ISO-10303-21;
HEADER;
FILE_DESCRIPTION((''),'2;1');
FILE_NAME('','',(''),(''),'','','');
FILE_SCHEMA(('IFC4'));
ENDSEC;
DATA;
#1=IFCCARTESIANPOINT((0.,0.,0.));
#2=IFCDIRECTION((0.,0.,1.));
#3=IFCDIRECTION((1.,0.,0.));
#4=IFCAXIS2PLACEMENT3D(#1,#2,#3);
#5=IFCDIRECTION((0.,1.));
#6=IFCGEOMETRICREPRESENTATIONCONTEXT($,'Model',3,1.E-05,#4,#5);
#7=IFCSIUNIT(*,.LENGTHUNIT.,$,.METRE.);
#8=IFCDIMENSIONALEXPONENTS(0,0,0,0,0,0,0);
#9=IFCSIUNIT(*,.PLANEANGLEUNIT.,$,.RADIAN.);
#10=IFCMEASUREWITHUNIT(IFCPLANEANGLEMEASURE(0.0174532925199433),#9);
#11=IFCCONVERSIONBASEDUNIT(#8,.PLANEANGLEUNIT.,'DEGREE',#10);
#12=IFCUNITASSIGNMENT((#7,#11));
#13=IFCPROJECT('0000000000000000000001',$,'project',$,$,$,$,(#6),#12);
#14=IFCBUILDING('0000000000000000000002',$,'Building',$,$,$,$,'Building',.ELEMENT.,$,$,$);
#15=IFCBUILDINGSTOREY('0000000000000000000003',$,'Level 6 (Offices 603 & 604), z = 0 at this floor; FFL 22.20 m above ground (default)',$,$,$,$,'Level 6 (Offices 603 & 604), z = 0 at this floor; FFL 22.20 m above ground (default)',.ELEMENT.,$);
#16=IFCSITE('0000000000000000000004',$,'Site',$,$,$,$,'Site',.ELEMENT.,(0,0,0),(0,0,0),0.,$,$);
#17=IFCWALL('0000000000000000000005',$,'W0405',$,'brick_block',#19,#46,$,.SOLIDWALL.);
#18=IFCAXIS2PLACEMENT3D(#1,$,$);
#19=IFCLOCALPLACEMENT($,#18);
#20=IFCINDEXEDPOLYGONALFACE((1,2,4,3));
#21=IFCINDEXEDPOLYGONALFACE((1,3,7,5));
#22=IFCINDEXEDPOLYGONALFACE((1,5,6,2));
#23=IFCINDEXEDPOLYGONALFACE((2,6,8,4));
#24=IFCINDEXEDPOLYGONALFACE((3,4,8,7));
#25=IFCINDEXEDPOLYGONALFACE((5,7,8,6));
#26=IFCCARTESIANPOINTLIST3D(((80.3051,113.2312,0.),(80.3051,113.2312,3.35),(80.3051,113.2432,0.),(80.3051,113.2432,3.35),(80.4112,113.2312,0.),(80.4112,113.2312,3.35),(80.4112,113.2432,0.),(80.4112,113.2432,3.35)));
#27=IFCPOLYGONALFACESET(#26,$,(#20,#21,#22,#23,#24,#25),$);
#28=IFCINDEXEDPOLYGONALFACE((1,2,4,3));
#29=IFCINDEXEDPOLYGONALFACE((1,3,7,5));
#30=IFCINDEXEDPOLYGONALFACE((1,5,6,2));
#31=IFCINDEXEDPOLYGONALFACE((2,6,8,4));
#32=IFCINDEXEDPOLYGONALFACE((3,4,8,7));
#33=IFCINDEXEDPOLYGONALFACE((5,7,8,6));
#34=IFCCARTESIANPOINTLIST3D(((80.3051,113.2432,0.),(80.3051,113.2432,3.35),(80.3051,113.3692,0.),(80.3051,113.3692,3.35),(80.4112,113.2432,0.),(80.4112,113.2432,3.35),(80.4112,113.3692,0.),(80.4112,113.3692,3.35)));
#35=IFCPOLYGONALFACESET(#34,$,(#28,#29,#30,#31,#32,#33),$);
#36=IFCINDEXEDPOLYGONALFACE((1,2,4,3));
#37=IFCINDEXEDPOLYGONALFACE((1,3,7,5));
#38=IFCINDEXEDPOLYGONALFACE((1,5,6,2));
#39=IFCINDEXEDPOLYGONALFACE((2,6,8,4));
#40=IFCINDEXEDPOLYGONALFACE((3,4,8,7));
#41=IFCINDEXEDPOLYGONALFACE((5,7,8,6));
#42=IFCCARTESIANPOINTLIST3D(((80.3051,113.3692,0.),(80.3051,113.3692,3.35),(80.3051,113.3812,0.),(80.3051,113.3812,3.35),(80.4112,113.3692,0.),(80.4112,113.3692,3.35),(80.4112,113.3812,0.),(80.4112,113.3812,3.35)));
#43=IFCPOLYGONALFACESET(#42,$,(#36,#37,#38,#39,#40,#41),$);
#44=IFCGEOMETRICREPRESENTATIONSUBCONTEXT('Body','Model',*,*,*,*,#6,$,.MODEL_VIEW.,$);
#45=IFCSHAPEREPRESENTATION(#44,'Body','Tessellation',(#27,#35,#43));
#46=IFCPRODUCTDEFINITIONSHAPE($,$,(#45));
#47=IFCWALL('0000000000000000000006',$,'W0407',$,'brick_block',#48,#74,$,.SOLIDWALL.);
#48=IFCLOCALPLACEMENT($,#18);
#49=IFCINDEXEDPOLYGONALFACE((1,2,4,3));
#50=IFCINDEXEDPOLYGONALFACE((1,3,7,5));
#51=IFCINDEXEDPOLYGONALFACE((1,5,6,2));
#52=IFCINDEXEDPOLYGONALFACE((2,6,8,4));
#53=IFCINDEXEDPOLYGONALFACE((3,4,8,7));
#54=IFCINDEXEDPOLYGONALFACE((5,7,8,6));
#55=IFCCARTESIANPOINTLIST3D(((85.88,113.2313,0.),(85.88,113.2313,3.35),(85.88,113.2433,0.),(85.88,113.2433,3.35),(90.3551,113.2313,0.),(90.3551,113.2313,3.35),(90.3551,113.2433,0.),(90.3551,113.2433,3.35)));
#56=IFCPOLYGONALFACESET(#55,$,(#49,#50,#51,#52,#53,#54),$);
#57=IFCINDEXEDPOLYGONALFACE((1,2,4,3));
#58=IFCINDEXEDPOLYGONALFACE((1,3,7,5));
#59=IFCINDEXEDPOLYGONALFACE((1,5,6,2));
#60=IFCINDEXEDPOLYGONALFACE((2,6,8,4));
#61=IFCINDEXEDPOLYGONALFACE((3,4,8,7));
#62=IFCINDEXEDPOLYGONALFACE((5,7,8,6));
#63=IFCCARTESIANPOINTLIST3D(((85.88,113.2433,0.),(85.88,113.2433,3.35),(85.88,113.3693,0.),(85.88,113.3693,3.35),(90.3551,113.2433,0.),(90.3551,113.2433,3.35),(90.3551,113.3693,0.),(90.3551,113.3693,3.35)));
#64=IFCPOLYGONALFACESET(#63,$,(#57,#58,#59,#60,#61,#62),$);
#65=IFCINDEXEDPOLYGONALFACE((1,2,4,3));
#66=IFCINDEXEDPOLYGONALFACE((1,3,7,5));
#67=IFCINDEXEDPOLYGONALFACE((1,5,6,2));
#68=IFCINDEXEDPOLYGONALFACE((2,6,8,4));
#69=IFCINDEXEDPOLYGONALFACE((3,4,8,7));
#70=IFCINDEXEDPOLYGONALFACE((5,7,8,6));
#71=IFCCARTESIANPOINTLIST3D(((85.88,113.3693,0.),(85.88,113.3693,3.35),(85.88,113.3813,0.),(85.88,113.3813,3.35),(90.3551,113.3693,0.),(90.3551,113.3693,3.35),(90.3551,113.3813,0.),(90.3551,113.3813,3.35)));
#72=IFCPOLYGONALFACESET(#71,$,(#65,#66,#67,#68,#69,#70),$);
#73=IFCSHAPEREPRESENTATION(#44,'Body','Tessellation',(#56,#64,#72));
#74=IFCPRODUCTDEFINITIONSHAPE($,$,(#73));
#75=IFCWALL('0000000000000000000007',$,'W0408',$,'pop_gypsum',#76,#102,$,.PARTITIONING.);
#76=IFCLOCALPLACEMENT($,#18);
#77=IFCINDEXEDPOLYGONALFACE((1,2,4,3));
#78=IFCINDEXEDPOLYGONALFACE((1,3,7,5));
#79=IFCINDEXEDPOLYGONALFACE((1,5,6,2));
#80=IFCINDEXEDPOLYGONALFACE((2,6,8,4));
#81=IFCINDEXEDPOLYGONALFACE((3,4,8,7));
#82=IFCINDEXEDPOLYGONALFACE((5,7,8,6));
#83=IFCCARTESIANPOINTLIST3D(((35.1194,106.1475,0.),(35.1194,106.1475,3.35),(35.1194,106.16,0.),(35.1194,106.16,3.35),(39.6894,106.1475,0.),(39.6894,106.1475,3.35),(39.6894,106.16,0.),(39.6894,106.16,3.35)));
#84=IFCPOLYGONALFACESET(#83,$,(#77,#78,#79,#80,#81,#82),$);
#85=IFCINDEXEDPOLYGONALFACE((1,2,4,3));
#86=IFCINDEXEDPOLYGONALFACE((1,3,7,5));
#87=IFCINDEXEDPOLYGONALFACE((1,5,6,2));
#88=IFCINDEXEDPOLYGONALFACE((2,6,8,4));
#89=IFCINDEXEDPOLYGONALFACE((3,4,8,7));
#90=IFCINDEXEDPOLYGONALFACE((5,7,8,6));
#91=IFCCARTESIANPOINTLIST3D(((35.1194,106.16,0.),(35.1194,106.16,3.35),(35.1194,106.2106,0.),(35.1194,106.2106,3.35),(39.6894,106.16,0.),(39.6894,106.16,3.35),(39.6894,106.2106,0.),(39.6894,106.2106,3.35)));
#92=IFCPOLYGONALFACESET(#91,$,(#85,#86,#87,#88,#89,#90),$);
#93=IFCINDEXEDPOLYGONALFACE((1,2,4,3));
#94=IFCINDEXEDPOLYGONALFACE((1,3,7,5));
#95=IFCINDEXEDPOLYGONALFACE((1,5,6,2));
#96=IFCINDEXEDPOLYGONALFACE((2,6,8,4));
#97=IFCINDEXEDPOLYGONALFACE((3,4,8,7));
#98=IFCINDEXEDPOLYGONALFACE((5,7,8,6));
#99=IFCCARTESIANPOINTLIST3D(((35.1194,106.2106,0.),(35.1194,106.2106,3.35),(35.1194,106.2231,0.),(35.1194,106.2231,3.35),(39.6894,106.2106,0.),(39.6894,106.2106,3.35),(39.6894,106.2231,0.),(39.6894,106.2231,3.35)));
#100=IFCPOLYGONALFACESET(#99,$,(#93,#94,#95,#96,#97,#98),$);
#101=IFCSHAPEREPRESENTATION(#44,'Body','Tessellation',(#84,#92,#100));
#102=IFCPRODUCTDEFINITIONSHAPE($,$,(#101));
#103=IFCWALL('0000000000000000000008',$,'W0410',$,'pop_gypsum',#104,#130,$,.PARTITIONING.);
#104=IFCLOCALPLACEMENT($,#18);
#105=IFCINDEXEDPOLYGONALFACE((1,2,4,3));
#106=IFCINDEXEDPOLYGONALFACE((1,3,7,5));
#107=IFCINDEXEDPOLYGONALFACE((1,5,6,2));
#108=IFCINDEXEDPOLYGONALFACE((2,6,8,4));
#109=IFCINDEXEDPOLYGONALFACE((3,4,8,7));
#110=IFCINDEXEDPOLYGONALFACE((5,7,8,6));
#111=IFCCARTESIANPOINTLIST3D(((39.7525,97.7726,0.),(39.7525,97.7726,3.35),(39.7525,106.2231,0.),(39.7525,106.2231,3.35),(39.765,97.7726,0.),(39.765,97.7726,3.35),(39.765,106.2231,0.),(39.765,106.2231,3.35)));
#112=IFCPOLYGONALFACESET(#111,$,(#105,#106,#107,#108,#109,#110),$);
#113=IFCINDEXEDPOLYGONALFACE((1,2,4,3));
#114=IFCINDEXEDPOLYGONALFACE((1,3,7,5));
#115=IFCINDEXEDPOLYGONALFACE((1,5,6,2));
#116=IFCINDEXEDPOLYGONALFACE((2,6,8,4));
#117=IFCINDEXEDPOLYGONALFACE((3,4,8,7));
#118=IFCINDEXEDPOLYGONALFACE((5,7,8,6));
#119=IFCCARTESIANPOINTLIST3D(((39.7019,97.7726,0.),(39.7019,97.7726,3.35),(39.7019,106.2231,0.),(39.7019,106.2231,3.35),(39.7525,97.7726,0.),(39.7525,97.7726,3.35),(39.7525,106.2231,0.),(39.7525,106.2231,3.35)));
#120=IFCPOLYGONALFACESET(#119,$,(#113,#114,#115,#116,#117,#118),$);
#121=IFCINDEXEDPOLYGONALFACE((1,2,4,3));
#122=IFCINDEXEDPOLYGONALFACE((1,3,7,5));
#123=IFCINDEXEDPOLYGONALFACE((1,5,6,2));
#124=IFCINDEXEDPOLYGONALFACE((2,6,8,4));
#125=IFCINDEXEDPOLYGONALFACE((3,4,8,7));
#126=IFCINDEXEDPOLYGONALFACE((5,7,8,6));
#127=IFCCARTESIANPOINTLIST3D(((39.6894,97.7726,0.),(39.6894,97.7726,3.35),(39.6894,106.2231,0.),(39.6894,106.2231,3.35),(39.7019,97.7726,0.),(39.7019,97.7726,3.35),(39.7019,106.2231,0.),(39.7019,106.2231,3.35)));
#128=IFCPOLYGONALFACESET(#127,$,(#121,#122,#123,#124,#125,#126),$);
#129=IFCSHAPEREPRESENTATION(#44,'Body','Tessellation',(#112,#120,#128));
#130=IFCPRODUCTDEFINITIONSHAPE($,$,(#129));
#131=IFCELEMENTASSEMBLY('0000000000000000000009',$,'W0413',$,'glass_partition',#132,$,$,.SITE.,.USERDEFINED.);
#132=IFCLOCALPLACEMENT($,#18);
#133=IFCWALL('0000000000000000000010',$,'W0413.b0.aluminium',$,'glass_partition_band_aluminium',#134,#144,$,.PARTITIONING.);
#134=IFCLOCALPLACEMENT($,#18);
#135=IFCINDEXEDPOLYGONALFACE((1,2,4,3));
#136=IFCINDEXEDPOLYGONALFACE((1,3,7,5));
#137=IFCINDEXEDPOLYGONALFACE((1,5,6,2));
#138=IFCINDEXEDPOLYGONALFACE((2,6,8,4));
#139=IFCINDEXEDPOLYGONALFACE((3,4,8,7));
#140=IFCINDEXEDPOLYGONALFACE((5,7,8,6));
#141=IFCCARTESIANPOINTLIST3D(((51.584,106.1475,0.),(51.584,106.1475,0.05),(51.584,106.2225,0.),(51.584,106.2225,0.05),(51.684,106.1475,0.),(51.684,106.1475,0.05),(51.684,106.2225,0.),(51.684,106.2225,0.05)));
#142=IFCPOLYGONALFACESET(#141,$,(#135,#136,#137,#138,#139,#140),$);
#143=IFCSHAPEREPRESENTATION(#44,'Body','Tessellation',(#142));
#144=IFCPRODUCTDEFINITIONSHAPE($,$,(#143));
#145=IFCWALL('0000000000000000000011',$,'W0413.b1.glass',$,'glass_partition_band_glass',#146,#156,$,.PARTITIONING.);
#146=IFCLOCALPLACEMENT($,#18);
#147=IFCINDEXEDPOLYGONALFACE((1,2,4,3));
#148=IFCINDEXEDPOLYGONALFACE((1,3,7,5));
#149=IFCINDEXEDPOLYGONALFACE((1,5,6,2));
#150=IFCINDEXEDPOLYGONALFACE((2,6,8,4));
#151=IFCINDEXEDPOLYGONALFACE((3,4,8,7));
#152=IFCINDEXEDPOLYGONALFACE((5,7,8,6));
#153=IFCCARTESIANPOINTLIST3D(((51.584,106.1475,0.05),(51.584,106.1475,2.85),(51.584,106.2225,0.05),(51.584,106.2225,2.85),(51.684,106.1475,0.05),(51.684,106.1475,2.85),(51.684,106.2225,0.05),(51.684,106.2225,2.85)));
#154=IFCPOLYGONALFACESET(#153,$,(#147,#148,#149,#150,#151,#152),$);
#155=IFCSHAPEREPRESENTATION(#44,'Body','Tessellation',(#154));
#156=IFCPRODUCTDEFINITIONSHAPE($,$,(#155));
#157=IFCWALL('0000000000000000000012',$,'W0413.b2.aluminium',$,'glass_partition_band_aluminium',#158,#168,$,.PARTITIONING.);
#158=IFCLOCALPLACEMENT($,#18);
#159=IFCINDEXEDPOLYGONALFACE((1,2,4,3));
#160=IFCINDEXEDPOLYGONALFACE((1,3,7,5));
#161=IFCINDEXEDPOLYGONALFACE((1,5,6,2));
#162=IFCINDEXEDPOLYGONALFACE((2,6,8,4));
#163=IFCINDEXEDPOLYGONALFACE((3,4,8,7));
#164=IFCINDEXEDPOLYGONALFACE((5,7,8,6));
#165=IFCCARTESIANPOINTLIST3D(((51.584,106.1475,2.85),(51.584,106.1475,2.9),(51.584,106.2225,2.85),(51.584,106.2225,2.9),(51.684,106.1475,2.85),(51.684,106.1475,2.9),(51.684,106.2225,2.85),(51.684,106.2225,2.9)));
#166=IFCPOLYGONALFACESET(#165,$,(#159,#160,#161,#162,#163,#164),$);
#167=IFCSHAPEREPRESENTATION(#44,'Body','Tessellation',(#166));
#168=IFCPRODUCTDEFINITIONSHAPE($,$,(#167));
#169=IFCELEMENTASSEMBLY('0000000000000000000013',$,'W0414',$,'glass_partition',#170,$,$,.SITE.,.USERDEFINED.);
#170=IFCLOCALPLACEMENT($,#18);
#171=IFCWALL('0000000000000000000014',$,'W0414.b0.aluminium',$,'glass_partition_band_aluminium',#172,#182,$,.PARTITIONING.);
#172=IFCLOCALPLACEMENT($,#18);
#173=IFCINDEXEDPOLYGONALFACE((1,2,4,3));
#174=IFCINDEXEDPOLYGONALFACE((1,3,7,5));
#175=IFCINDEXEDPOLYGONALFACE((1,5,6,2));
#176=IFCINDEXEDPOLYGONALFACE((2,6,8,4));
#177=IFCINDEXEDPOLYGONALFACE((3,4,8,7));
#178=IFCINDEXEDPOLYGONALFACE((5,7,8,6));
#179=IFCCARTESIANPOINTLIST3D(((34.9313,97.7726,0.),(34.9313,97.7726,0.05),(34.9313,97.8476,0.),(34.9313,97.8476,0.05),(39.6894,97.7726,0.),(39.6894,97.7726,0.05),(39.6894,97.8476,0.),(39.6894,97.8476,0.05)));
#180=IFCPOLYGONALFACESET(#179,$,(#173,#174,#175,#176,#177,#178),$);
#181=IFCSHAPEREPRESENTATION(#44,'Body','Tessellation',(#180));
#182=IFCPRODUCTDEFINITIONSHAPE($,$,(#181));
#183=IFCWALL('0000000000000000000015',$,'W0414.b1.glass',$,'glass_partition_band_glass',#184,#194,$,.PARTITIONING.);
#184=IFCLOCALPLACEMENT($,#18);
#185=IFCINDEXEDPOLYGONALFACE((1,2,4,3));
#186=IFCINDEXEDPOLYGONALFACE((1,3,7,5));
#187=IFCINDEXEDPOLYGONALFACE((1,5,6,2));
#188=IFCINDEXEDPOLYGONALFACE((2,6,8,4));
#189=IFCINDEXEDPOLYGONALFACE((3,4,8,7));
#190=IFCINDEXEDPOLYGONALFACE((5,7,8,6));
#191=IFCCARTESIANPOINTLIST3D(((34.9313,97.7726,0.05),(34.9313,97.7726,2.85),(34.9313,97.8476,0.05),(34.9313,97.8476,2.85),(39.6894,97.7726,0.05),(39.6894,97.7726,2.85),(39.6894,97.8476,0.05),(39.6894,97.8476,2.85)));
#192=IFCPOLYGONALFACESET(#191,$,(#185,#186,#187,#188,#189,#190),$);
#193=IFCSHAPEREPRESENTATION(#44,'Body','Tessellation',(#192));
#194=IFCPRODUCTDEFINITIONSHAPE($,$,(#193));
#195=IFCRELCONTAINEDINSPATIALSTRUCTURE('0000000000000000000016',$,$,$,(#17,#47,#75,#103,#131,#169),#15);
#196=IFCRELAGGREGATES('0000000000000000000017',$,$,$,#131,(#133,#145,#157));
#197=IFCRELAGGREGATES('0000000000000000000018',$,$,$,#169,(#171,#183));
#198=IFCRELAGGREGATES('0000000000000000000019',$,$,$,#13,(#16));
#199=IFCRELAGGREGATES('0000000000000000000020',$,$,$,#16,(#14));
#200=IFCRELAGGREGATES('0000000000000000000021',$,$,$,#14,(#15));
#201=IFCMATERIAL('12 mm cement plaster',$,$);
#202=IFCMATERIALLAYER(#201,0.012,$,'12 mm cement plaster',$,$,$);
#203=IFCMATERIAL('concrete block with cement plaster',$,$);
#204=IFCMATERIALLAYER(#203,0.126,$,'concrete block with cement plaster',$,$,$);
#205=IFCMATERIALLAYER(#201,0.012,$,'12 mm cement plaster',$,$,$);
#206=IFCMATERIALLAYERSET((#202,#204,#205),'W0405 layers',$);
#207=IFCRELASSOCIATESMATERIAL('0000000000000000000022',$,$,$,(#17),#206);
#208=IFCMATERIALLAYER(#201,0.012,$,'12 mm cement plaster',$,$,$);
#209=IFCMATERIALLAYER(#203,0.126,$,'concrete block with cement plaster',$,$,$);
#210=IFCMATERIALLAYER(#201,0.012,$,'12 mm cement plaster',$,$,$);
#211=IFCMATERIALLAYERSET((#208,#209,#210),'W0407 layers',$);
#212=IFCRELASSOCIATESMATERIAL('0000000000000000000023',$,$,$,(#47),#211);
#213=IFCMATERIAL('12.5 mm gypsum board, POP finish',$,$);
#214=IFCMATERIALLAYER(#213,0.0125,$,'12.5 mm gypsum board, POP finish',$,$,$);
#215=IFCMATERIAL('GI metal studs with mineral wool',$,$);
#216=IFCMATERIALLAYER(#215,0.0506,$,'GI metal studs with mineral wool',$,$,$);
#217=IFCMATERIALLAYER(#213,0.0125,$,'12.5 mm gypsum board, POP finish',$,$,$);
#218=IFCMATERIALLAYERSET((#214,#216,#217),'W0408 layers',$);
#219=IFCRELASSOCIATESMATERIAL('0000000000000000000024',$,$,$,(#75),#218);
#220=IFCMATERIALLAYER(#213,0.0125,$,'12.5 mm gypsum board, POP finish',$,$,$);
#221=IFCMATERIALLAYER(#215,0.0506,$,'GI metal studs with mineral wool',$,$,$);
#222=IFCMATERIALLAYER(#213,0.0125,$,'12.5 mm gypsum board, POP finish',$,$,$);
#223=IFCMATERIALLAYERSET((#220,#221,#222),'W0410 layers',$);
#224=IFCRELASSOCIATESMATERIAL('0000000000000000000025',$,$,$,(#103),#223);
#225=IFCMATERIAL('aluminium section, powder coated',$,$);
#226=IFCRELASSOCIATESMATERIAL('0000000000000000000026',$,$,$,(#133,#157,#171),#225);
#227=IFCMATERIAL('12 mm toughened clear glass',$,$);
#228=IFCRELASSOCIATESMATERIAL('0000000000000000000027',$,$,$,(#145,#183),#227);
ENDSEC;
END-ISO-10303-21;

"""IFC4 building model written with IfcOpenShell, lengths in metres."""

from ifc_helpers import new_model, entity, si_unit, converted_unit, direction, frame, frame_2d, origin_with_axes, origin_2d_with_axis, place, context, subcontext, project, spatial, rectangle, extrude, material, layer, layer_set, layer_usage, element, aggregate, save


model = new_model("IFC4")

# Units and contexts
model_context = context("Model", 3, precision=1e-05, world=origin_with_axes(), true_north=direction((0.0, 1.0)))
body_context = subcontext(model_context, "Body", "Model", "MODEL_VIEW")
ifc_project = project(units=[si_unit("LENGTHUNIT", "METRE"), converted_unit("PLANEANGLEUNIT", "DEGREE", entity("IfcPlaneAngleMeasure", 0.0174532925199433), si_unit("PLANEANGLEUNIT", "RADIAN"), dimensions=[0, 0, 0, 0, 0, 0, 0])], contexts=[model_context])

# Site, building, storey
site = spatial("IfcSite", under=ifc_project, Name="Site", LongName="Site", CompositionType="ELEMENT", RefLatitude=(0, 0, 0), RefLongitude=(0, 0, 0), RefElevation=0.0)
building = spatial("IfcBuilding", under=site, Name="Building", LongName="Building", CompositionType="ELEMENT")
storey = spatial("IfcBuildingStorey", under=building, Name="Level 6 (Offices 603 & 604), z = 0 at this floor; FFL 22.20 m above ground (default)", LongName="Level 6 (Offices 603 & 604), z = 0 at this floor; FFL 22.20 m above ground (default)", CompositionType="ELEMENT")

# Shared definitions
ifc_material_1 = material(Name="aluminium section, powder coated")
placement = place(None, origin_with_axes())

# Shared definitions
ifc_material_2 = material(Name="12.5 mm gypsum board, POP finish")
ifc_material_3 = material(Name="GI metal studs with mineral wool")

# Shared definitions
ifc_material_4 = material(Name="12 mm toughened clear glass")

# Walls
ifc_material_5 = material(Name="12 mm cement plaster")
ifc_material_6 = material(Name="concrete block with cement plaster")
ifc_layer_1 = layer(ifc_material_5, 0.012, Name="12 mm cement plaster")
ifc_layer_2 = layer(ifc_material_6, 0.126, Name="concrete block with cement plaster")
ifc_layer_3 = layer(ifc_material_5, 0.012, Name="12 mm cement plaster")
ifc_layer_set_1 = layer_set([ifc_layer_1, ifc_layer_2, ifc_layer_3], Name="W0405 layers")
ifc_layer_usage_1 = layer_usage(ifc_layer_set_1, "AXIS2", "POSITIVE", -0.075)
element("IfcWall", 1, at=placement, inside=storey, material=ifc_layer_usage_1, Name="W0405", ObjectType="brick_block", PredefinedType="SOLIDWALL", context=body_context, shape_type="SweptSolid", body=[
    extrude(rectangle(XDim=0.1061, YDim=0.012, at=origin_2d_with_axis()), frame((80.3581, 113.2372, 0.0), z_axis=(0.0, 0.0, 1.0), x_axis=(1.0, 0.0, 0.0)), (0.0, 0.0, 1.0), 3.35),
    extrude(rectangle(XDim=0.1061, YDim=0.126, at=frame_2d((0.0, 0.069), x_axis=(1.0, 0.0))), frame((80.3581, 113.2372, 0.0), z_axis=(0.0, 0.0, 1.0), x_axis=(1.0, 0.0, 0.0)), (0.0, 0.0, 1.0), 3.35),
    extrude(rectangle(XDim=0.1061, YDim=0.012, at=frame_2d((0.0, 0.138), x_axis=(1.0, 0.0))), frame((80.3581, 113.2372, 0.0), z_axis=(0.0, 0.0, 1.0), x_axis=(1.0, 0.0, 0.0)), (0.0, 0.0, 1.0), 3.35),
])
ifc_layer_4 = layer(ifc_material_5, 0.012, Name="12 mm cement plaster")
ifc_layer_5 = layer(ifc_material_6, 0.126, Name="concrete block with cement plaster")
ifc_layer_6 = layer(ifc_material_5, 0.012, Name="12 mm cement plaster")
ifc_layer_set_2 = layer_set([ifc_layer_4, ifc_layer_5, ifc_layer_6], Name="W0407 layers")
ifc_layer_usage_2 = layer_usage(ifc_layer_set_2, "AXIS2", "POSITIVE", -0.075)
element("IfcWall", 2, at=placement, inside=storey, material=ifc_layer_usage_2, Name="W0407", ObjectType="brick_block", PredefinedType="SOLIDWALL", context=body_context, shape_type="SweptSolid", body=[
    extrude(rectangle(XDim=4.4751, YDim=0.012, at=frame_2d((0.0, 0.0), x_axis=(1.0, 0.0))), frame((88.1175, 113.2373, 0.0), z_axis=(0.0, 0.0, 1.0), x_axis=(1.0, 0.0, 0.0)), (0.0, 0.0, 1.0), 3.35),
    extrude(rectangle(XDim=4.4751, YDim=0.126, at=frame_2d((0.0, 0.069), x_axis=(1.0, 0.0))), frame((88.1175, 113.2373, 0.0), z_axis=(0.0, 0.0, 1.0), x_axis=(1.0, 0.0, 0.0)), (0.0, 0.0, 1.0), 3.35),
    extrude(rectangle(XDim=4.4751, YDim=0.012, at=frame_2d((0.0, 0.138), x_axis=(1.0, 0.0))), frame((88.1175, 113.2373, 0.0), z_axis=(0.0, 0.0, 1.0), x_axis=(1.0, 0.0, 0.0)), (0.0, 0.0, 1.0), 3.35),
])
ifc_layer_7 = layer(ifc_material_2, 0.0125, Name="12.5 mm gypsum board, POP finish")
ifc_layer_8 = layer(ifc_material_3, 0.0506, Name="GI metal studs with mineral wool")
ifc_layer_9 = layer(ifc_material_2, 0.0125, Name="12.5 mm gypsum board, POP finish")
ifc_layer_set_3 = layer_set([ifc_layer_7, ifc_layer_8, ifc_layer_9], Name="W0408 layers")
ifc_layer_usage_3 = layer_usage(ifc_layer_set_3, "AXIS2", "POSITIVE", -0.0378)
element("IfcWall", 3, at=placement, inside=storey, material=ifc_layer_usage_3, Name="W0408", ObjectType="pop_gypsum", PredefinedType="PARTITIONING", context=body_context, shape_type="SweptSolid", body=[
    extrude(rectangle(XDim=4.57, YDim=0.0125, at=frame_2d((0.0, 0.0), x_axis=(1.0, 0.0))), frame((37.4044, 106.1538, 0.0), z_axis=(0.0, 0.0, 1.0), x_axis=(1.0, 0.0, 0.0)), (0.0, 0.0, 1.0), 3.35),
    extrude(rectangle(XDim=4.57, YDim=0.0506, at=frame_2d((0.0, 0.0315), x_axis=(1.0, 0.0))), frame((37.4044, 106.1538, 0.0), z_axis=(0.0, 0.0, 1.0), x_axis=(1.0, 0.0, 0.0)), (0.0, 0.0, 1.0), 3.35),
    extrude(rectangle(XDim=4.57, YDim=0.0125, at=frame_2d((0.0, 0.0631), x_axis=(1.0, 0.0))), frame((37.4044, 106.1538, 0.0), z_axis=(0.0, 0.0, 1.0), x_axis=(1.0, 0.0, 0.0)), (0.0, 0.0, 1.0), 3.35),
])
ifc_layer_10 = layer(ifc_material_2, 0.0125, Name="12.5 mm gypsum board, POP finish")
ifc_layer_11 = layer(ifc_material_3, 0.0506, Name="GI metal studs with mineral wool")
ifc_layer_12 = layer(ifc_material_2, 0.0125, Name="12.5 mm gypsum board, POP finish")
ifc_layer_set_4 = layer_set([ifc_layer_10, ifc_layer_11, ifc_layer_12], Name="W0410 layers")
ifc_layer_usage_4 = layer_usage(ifc_layer_set_4, "AXIS2", "POSITIVE", -0.0378)
element("IfcWall", 4, at=placement, inside=storey, material=ifc_layer_usage_4, Name="W0410", ObjectType="pop_gypsum", PredefinedType="PARTITIONING", context=body_context, shape_type="SweptSolid", body=[
    extrude(rectangle(XDim=8.4505, YDim=0.0125, at=frame_2d((0.0, 0.0), x_axis=(0.0, 1.0))), frame((39.7587, 101.9978, 0.0), z_axis=(0.0, 0.0, 1.0), x_axis=(1.0, 0.0, 0.0)), (0.0, 0.0, 1.0), 3.35),
    extrude(rectangle(XDim=8.4505, YDim=0.0506, at=frame_2d((-0.0315, 0.0), x_axis=(0.0, 1.0))), frame((39.7587, 101.9978, 0.0), z_axis=(0.0, 0.0, 1.0), x_axis=(1.0, 0.0, 0.0)), (0.0, 0.0, 1.0), 3.35),
    extrude(rectangle(XDim=8.4505, YDim=0.0125, at=frame_2d((-0.0631, 0.0), x_axis=(0.0, 1.0))), frame((39.7587, 101.9978, 0.0), z_axis=(0.0, 0.0, 1.0), x_axis=(1.0, 0.0, 0.0)), (0.0, 0.0, 1.0), 3.35),
])

# Element assemblies, walls
assembly_1 = element("IfcElementAssembly", 5, inside=storey, Name="W0413", ObjectType="glass_partition", AssemblyPlace="SITE", PredefinedType="USERDEFINED")
wall_1 = element("IfcWall", 6, at=placement, material=ifc_material_1, Name="W0413.b0.aluminium", ObjectType="glass_partition_band_aluminium", PredefinedType="PARTITIONING", context=body_context, shape_type="SweptSolid", body=[
    extrude(rectangle(XDim=0.1, YDim=0.075, at=frame_2d((0.0, 0.0), x_axis=(1.0, 0.0))), frame((51.634, 106.185, 0.0), z_axis=(0.0, 0.0, 1.0), x_axis=(1.0, 0.0, 0.0)), (0.0, 0.0, 1.0), 0.05),
])
wall_2 = element("IfcWall", 7, at=placement, material=ifc_material_4, Name="W0413.b1.glass", ObjectType="glass_partition_band_glass", PredefinedType="PARTITIONING", context=body_context, shape_type="SweptSolid", body=[
    extrude(rectangle(XDim=0.1, YDim=0.075, at=frame_2d((0.0, 0.0), x_axis=(1.0, 0.0))), frame((51.634, 106.185, 0.05), z_axis=(0.0, 0.0, 1.0), x_axis=(1.0, 0.0, 0.0)), (0.0, 0.0, 1.0), 2.8),
])
wall_3 = element("IfcWall", 8, at=placement, material=ifc_material_1, Name="W0413.b2.aluminium", ObjectType="glass_partition_band_aluminium", PredefinedType="PARTITIONING", context=body_context, shape_type="SweptSolid", body=[
    extrude(rectangle(XDim=0.1, YDim=0.075, at=frame_2d((0.0, 0.0), x_axis=(1.0, 0.0))), frame((51.634, 106.185, 2.85), z_axis=(0.0, 0.0, 1.0), x_axis=(1.0, 0.0, 0.0)), (0.0, 0.0, 1.0), 0.05),
])
aggregate(assembly_1, [wall_1, wall_2, wall_3])
assembly_2 = element("IfcElementAssembly", 9, inside=storey, Name="W0414", ObjectType="glass_partition", AssemblyPlace="SITE", PredefinedType="USERDEFINED")
wall_4 = element("IfcWall", 10, at=placement, material=ifc_material_1, Name="W0414.b0.aluminium", ObjectType="glass_partition_band_aluminium", PredefinedType="PARTITIONING", context=body_context, shape_type="SweptSolid", body=[
    extrude(rectangle(XDim=4.7581, YDim=0.075, at=frame_2d((0.0, 0.0), x_axis=(1.0, 0.0))), frame((37.3103, 97.8101, 0.0), z_axis=(0.0, 0.0, 1.0), x_axis=(1.0, 0.0, 0.0)), (0.0, 0.0, 1.0), 0.05),
])
wall_5 = element("IfcWall", 11, at=placement, material=ifc_material_4, Name="W0414.b1.glass", ObjectType="glass_partition_band_glass", PredefinedType="PARTITIONING", context=body_context, shape_type="SweptSolid", body=[
    extrude(rectangle(XDim=4.7581, YDim=0.075, at=frame_2d((0.0, 0.0), x_axis=(1.0, 0.0))), frame((37.3103, 97.8101, 0.05), z_axis=(0.0, 0.0, 1.0), x_axis=(1.0, 0.0, 0.0)), (0.0, 0.0, 1.0), 2.8),
])
aggregate(assembly_2, [wall_4, wall_5])

save(model, "model.ifc")
